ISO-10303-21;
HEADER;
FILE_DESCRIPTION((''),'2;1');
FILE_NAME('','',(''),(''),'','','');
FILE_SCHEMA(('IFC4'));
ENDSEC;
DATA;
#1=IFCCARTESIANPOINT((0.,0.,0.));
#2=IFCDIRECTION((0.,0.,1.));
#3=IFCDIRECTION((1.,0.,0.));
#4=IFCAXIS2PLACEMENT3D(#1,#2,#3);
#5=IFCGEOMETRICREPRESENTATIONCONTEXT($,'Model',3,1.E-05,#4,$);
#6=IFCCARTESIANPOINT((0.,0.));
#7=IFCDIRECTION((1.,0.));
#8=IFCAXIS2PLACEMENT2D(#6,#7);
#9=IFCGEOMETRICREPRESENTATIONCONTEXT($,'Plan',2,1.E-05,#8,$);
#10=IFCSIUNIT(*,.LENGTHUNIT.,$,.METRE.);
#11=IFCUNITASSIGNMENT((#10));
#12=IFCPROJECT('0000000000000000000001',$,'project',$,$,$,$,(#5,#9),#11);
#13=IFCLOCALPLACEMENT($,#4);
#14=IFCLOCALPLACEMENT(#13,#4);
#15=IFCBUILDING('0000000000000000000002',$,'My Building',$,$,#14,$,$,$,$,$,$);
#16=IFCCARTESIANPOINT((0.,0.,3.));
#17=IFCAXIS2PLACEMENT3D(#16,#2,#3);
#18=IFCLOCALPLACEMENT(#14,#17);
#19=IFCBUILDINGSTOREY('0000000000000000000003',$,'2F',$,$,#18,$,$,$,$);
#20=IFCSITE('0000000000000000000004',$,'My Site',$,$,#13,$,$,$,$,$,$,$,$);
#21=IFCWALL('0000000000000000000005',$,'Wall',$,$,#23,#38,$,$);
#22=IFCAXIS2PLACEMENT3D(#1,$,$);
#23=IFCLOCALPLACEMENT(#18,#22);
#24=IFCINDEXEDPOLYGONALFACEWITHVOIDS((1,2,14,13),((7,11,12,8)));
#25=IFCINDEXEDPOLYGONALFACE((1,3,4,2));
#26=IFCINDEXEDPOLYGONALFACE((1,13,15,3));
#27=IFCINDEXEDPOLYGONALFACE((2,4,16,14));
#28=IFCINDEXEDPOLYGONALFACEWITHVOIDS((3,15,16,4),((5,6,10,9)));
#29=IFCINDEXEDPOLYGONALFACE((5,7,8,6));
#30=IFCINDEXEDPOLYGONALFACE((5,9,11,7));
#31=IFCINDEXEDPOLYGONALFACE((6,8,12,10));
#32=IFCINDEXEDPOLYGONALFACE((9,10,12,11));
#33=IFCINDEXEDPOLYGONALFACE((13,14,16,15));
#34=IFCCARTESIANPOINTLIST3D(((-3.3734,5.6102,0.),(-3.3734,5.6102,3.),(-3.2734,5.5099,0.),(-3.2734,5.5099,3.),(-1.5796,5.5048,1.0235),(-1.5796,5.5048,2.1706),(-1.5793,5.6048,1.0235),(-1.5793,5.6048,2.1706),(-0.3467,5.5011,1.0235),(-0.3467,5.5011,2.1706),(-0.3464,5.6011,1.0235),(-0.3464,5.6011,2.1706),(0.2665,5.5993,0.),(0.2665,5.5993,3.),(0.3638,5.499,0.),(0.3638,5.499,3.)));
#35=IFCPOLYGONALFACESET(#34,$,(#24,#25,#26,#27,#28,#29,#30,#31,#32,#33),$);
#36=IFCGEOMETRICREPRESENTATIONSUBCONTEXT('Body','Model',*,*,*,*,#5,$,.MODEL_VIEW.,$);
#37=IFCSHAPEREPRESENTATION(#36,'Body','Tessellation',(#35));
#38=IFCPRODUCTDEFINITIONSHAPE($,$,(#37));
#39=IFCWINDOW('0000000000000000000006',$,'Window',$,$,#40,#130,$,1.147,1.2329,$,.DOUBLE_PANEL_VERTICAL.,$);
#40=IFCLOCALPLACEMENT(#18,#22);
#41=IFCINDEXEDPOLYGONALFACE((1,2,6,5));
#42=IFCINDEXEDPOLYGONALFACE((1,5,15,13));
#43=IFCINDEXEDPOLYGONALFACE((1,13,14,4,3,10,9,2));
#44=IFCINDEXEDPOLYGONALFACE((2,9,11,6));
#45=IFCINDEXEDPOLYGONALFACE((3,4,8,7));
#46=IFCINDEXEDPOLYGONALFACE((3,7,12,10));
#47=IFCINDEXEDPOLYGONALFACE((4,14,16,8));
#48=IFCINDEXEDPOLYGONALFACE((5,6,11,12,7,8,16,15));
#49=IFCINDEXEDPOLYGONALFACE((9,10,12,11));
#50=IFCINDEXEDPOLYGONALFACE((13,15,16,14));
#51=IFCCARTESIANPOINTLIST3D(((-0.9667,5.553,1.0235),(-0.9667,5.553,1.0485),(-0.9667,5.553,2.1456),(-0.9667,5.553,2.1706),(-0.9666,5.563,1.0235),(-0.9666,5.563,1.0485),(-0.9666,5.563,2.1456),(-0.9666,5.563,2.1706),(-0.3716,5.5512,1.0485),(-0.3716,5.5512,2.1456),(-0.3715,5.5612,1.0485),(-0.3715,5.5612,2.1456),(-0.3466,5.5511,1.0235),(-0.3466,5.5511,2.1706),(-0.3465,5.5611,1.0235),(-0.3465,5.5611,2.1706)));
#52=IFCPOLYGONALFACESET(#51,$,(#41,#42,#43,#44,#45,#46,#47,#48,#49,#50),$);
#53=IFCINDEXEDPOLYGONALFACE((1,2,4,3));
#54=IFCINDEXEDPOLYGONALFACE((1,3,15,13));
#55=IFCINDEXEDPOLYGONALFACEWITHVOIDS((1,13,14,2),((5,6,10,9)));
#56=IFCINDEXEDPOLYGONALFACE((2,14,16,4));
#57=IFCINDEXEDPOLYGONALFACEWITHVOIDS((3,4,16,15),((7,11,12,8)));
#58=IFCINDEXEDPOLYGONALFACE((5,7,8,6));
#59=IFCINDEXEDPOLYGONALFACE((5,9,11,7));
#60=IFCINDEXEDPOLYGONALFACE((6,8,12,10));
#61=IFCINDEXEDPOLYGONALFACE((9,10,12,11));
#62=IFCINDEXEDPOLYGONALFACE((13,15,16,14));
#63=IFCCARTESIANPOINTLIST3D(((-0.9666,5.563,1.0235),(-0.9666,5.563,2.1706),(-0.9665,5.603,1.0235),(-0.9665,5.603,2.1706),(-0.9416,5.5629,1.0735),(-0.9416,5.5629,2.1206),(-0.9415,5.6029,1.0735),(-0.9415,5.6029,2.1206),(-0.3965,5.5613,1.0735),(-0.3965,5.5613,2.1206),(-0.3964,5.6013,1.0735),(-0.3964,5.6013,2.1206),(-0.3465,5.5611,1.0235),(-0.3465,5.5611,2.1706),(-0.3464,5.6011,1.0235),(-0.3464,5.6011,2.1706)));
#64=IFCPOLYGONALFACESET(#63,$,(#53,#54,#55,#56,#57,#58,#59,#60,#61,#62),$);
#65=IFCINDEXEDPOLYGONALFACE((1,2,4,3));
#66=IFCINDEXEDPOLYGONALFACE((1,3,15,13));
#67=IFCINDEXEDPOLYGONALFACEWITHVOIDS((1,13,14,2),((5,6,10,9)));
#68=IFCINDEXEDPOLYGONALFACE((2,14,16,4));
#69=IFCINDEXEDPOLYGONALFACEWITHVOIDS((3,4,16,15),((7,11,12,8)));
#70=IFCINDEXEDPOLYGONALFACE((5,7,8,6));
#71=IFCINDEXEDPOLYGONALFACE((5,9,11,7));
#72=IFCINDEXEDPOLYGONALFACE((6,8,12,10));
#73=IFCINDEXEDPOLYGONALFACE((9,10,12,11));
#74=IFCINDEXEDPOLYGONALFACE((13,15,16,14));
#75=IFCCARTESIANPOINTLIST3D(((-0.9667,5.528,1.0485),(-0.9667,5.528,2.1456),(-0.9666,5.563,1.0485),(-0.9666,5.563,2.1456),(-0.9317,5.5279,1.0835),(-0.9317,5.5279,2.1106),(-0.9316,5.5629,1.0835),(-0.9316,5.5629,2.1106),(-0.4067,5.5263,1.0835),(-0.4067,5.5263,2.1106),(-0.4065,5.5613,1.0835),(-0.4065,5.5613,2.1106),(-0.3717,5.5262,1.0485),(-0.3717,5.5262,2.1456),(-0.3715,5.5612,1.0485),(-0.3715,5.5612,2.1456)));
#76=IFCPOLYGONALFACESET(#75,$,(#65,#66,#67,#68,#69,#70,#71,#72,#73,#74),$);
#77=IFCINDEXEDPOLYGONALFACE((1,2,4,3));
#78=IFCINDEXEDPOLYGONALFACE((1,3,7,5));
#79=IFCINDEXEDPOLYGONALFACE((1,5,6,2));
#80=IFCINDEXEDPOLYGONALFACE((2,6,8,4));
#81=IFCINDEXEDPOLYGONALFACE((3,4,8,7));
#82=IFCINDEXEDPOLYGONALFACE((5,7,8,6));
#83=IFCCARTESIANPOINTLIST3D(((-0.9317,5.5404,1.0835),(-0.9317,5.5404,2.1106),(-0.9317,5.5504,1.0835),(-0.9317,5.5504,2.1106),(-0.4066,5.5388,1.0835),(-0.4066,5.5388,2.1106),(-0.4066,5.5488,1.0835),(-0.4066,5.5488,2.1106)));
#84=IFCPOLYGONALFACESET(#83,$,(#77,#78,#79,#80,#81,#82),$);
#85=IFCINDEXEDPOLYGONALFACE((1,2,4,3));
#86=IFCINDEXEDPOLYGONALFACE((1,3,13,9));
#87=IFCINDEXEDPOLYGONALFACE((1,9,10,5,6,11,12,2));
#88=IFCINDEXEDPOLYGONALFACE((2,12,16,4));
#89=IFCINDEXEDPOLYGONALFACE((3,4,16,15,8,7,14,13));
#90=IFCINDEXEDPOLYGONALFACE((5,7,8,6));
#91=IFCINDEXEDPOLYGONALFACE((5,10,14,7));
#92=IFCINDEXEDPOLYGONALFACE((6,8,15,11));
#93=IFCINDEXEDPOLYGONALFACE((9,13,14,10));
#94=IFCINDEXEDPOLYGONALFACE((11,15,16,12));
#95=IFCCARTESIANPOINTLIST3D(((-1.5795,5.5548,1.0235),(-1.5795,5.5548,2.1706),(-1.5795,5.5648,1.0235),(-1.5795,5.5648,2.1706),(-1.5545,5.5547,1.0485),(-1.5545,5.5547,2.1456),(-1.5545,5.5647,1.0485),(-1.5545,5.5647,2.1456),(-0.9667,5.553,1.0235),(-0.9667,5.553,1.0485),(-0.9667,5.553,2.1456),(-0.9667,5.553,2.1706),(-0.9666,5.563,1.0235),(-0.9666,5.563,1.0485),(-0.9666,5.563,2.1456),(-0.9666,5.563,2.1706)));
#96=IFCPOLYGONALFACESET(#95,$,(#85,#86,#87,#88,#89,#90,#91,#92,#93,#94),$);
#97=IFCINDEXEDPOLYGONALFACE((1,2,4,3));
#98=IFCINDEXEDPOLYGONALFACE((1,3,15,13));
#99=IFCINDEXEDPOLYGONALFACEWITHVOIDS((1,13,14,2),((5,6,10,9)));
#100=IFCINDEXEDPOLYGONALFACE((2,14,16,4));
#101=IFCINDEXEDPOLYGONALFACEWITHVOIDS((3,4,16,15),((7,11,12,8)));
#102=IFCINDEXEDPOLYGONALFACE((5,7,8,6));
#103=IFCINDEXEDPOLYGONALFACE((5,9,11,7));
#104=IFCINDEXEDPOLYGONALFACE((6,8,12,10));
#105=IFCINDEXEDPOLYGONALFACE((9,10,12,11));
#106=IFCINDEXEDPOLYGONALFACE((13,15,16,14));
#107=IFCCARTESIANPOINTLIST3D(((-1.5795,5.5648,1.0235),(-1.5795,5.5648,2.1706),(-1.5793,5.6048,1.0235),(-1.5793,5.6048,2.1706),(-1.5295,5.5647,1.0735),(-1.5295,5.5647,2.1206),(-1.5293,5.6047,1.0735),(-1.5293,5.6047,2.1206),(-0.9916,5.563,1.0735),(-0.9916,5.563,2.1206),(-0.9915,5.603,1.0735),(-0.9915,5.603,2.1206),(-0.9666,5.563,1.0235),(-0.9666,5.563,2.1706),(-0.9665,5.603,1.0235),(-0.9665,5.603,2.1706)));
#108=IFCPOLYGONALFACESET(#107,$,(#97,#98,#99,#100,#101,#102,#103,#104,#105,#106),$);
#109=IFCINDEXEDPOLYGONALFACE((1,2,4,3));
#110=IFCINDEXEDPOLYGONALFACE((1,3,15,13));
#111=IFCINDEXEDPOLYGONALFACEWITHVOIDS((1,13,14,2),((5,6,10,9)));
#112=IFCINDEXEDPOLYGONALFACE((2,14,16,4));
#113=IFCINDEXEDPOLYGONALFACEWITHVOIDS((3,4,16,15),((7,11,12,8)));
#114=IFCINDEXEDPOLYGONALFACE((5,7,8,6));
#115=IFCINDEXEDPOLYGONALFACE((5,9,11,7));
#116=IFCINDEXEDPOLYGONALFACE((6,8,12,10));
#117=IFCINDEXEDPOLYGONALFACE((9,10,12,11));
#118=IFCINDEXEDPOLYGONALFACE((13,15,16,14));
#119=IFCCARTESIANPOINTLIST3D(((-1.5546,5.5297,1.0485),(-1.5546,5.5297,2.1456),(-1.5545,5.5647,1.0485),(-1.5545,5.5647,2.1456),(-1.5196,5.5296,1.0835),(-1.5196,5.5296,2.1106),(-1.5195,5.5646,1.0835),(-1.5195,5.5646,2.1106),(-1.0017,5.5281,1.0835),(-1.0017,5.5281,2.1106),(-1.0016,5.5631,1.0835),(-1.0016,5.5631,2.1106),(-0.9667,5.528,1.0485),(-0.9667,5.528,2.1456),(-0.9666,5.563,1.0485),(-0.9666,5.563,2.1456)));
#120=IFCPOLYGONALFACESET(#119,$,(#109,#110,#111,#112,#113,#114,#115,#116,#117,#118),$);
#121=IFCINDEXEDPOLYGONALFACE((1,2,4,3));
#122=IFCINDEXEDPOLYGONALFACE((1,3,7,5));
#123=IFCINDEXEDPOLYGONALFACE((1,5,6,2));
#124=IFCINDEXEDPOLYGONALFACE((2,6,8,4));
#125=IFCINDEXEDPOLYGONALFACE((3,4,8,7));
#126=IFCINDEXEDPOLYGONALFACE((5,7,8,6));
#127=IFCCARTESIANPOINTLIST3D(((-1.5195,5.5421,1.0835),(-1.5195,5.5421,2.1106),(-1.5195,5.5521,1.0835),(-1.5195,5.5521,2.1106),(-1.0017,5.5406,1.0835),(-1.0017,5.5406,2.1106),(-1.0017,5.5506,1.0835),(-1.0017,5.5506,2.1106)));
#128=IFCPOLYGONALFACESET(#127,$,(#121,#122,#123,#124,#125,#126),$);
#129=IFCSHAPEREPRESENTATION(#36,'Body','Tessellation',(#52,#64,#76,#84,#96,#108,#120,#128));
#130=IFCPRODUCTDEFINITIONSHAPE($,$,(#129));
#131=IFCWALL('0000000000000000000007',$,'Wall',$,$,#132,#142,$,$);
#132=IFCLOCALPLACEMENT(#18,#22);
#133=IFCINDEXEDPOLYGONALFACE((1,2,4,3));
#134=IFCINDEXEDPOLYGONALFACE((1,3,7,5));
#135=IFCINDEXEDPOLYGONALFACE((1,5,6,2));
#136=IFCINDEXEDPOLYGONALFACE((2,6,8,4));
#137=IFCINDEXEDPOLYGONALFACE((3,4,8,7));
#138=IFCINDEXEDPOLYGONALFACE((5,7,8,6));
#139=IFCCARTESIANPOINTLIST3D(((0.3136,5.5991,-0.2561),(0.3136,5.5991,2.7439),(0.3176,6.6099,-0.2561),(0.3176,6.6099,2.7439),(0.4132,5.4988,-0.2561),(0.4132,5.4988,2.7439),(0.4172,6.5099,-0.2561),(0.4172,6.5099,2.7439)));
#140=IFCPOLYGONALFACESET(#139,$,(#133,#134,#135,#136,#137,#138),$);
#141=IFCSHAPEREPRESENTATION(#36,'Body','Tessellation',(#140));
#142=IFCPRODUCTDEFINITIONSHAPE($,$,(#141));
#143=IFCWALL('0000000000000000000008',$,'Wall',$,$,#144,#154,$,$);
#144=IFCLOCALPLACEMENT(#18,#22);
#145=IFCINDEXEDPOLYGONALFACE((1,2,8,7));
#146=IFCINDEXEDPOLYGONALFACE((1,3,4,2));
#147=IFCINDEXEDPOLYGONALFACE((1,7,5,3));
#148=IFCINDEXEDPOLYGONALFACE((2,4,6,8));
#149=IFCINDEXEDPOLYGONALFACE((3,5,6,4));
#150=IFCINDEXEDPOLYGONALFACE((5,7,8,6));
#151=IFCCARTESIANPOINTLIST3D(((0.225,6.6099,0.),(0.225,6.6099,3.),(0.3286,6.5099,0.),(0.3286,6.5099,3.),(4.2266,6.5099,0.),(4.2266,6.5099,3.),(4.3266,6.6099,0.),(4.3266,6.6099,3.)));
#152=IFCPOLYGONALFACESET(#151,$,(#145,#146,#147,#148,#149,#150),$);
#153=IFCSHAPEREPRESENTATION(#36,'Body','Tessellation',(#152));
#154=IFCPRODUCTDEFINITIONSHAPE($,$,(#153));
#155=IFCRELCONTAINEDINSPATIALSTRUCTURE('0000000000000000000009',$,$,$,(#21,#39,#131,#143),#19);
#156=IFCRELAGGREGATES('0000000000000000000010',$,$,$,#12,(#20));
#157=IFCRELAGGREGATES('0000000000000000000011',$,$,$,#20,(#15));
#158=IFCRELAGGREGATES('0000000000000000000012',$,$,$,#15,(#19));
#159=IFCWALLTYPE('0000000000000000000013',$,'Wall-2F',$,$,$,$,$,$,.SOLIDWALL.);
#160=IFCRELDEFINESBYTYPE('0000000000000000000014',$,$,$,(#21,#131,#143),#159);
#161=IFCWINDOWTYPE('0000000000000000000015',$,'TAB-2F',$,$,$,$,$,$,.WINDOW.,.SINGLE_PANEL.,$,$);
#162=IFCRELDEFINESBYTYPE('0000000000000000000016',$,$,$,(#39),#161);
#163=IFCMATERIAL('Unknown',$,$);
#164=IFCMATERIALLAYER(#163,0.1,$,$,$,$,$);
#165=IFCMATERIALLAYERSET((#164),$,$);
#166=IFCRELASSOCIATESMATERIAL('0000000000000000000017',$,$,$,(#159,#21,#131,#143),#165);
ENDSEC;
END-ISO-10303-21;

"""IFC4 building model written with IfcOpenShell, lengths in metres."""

from ifc_helpers import new_model, entity, si_unit, frame, origin_with_axes, origin_2d_with_axis, place, context, subcontext, project, spatial, line, indexed_curve, outline, extrude, shape, source, transform, mapped, material, layer, layer_set, layer_usage, type_object, type_shapes, element, fill, save


model = new_model("IFC4")

# Units and contexts
model_context = context("Model", 3, precision=1e-05, world=origin_with_axes())
plan_context = context("Plan", 2, precision=1e-05, world=origin_2d_with_axis())
body_context_1 = subcontext(model_context, "Body", "Model", "MODEL_VIEW")
body_context_2 = subcontext(plan_context, "Body", "Plan", "PLAN_VIEW")
ifc_project = project(units=[si_unit("LENGTHUNIT", "METRE")], contexts=[model_context, plan_context])

# Site, building, storey
site_placement = place(None, origin_with_axes())
site = spatial("IfcSite", under=ifc_project, at=site_placement, Name="My Site")
building_placement = place(site_placement, origin_with_axes())
building = spatial("IfcBuilding", under=site, at=building_placement, Name="My Building")
storey_placement = place(building_placement, frame((0.0, 0.0, 3.0), z_axis=(0.0, 0.0, 1.0), x_axis=(1.0, 0.0, 0.0)))
storey = spatial("IfcBuildingStorey", under=building, at=storey_placement, Name="2F")

# Shared definitions
ifc_material = material(Name="Unknown")

# Shared definitions
ifc_layer_1 = layer(ifc_material, 0.1)
ifc_layer_set_1 = layer_set([ifc_layer_1])
wall_type = type_object("IfcWallType", Name="Wall-2F", PredefinedType="SOLIDWALL", material=ifc_layer_set_1)

# Wall, opening, window
ifc_layer_usage_1 = layer_usage(ifc_layer_set_1, "AXIS2", "NEGATIVE", 0.0)
wall_1_placement = place(storey_placement, frame((-3.2734, 5.6099, 0.0), z_axis=(0.0, 0.0, 1.0), x_axis=(0.999995, -0.003003, 0.0)))
wall_1 = element("IfcWall", 1, at=wall_1_placement, inside=storey, type_object=wall_type, material=ifc_layer_usage_1, Name="Wall", context=body_context_1, shape_type="SweptSolid", body=[
    extrude(outline(indexed_curve([(0.0003, -0.1), (-0.1, 0.0), (3.5399, 0.0), (3.6375, -0.1)], segments=[line(1, 2, 3, 4, 1)])), origin_with_axes(), (0.0, 0.0, 1.0), 3.0),
])
shared_shape_1 = source(origin_with_axes(), body_context_1, "Body", "SweptSolid", [
    extrude(outline(indexed_curve([(0.0, 0.0), (1.2329, 0.0), (1.2329, 1.147), (0.0, 1.147)], segments=[line(1, 2, 3, 4, 1)])), frame((0.0, -0.6, 0.0), z_axis=(0.0, -1.0, 0.0), x_axis=(1.0, 0.0, 0.0)), (0.0, 0.0, -1.0), 1.2),
])
opening_1_placement = place(wall_1_placement, frame((2.927, 0.05, 1.0235), z_axis=(0.0, 0.0, 1.0), x_axis=(-1.0, 0.0, 0.0)))
opening_1 = element("IfcOpeningElement", 2, at=opening_1_placement, cuts=wall_1, PredefinedType="OPENING", context=body_context_1, shape_type="MappedRepresentation", body=[
    mapped(shared_shape_1, transform((0.0, 0.0, 0.0), x_axis=(1.0, 0.0, 0.0), y_axis=(0.0, 1.0, 0.0), z_axis=(0.0, 0.0, 1.0), scale=1.0)),
])
window_type_1 = type_object("IfcWindowType", Name="TAB-2F", PartitioningType="SINGLE_PANEL", PredefinedType="WINDOW")
shared_shape_2 = source(origin_with_axes(), body_context_1, "Body", "SweptSolid", [
    extrude(outline(indexed_curve([(0.6201, 0.0), (0.0, 0.0), (0.0, 1.147), (0.6201, 1.147), (0.6201, 1.122), (0.025, 1.122), (0.025, 0.025), (0.6201, 0.025)], segments=[line(1, 2, 3, 4, 5, 6, 7, 8, 1)])), frame((0.0, 0.09, 0.0), z_axis=(0.0, -1.0, 0.0), x_axis=(1.0, 0.0, 0.0)), (0.0, 0.0, -1.0), 0.01),
    extrude(outline(indexed_curve([(0.0, 0.0), (0.6201, 0.0), (0.6201, 1.147), (0.0, 1.147)], segments=[line(1, 2, 3, 4, 1)]), holes=[indexed_curve([(0.05, 0.05), (0.5951, 0.05), (0.5951, 1.097), (0.05, 1.097)], segments=[line(1, 2, 3, 4, 1)])]), frame((0.0, 0.05, 0.0), z_axis=(0.0, -1.0, 0.0), x_axis=(1.0, 0.0, 0.0)), (0.0, 0.0, -1.0), 0.04),
    extrude(outline(indexed_curve([(0.0, 0.0), (0.5951, 0.0), (0.5951, 1.097), (0.0, 1.097)], segments=[line(1, 2, 3, 4, 1)]), holes=[indexed_curve([(0.035, 0.035), (0.5601, 0.035), (0.5601, 1.062), (0.035, 1.062)], segments=[line(1, 2, 3, 4, 1)])]), frame((0.025, 0.09, 0.025), z_axis=(0.0, -1.0, 0.0), x_axis=(1.0, 0.0, 0.0)), (0.0, 0.0, -1.0), 0.035),
    extrude(outline(indexed_curve([(0.035, 0.035), (0.5601, 0.035), (0.5601, 1.062), (0.035, 1.062)], segments=[line(1, 2, 3, 4, 1)])), frame((0.025, 0.1025, 0.025), z_axis=(0.0, -1.0, 0.0), x_axis=(1.0, 0.0, 0.0)), (0.0, 0.0, -1.0), 0.01),
    extrude(outline(indexed_curve([(0.0, 1.147), (0.6128, 1.147), (0.6128, 0.0), (0.0, 0.0), (0.0, 0.025), (0.5878, 0.025), (0.5878, 1.122), (0.0, 1.122)], segments=[line(1, 2, 3, 4, 5, 6, 7, 8, 1)])), frame((0.6201, 0.09, 0.0), z_axis=(0.0, -1.0, 0.0), x_axis=(1.0, 0.0, 0.0)), (0.0, 0.0, -1.0), 0.01),
    extrude(outline(indexed_curve([(0.0, 0.0), (0.6128, 0.0), (0.6128, 1.147), (0.0, 1.147)], segments=[line(1, 2, 3, 4, 1)]), holes=[indexed_curve([(0.025, 0.05), (0.5628, 0.05), (0.5628, 1.097), (0.025, 1.097)], segments=[line(1, 2, 3, 4, 1)])]), frame((0.6201, 0.05, 0.0), z_axis=(0.0, -1.0, 0.0), x_axis=(1.0, 0.0, 0.0)), (0.0, 0.0, -1.0), 0.04),
    extrude(outline(indexed_curve([(0.0, 0.0), (0.5878, 0.0), (0.5878, 1.097), (0.0, 1.097)], segments=[line(1, 2, 3, 4, 1)]), holes=[indexed_curve([(0.035, 0.035), (0.5528, 0.035), (0.5528, 1.062), (0.035, 1.062)], segments=[line(1, 2, 3, 4, 1)])]), frame((0.6201, 0.09, 0.025), z_axis=(0.0, -1.0, 0.0), x_axis=(1.0, 0.0, 0.0)), (0.0, 0.0, -1.0), 0.035),
    extrude(outline(indexed_curve([(0.035, 0.035), (0.5528, 0.035), (0.5528, 1.062), (0.035, 1.062)], segments=[line(1, 2, 3, 4, 1)])), frame((0.6201, 0.1025, 0.025), z_axis=(0.0, -1.0, 0.0), x_axis=(1.0, 0.0, 0.0)), (0.0, 0.0, -1.0), 0.01),
])
shared_shape_3 = source(origin_with_axes(), body_context_2, "Body", "Curve2D", [
    entity("IfcIndexedPolyCurve", entity("IfcCartesianPointList2D", [[0.05, 0.05], [0.5951, 0.05]])),
    entity("IfcIndexedPolyCurve", entity("IfcCartesianPointList2D", [[0.0, 0.1], [0.025, 0.1], [0.025, 0.09], [0.05, 0.09], [0.05, 0.05], [0.0, 0.05]]), [entity("IfcLineIndex", [1, 2, 3, 4, 5, 6, 1])]),
    entity("IfcIndexedPolyCurve", entity("IfcCartesianPointList2D", [[0.6201, 0.1], [0.6201, 0.1], [0.6201, 0.09], [0.5951, 0.09], [0.5951, 0.05], [0.6201, 0.05]])),
    entity("IfcIndexedPolyCurve", entity("IfcCartesianPointList2D", [[0.025, 0.09], [0.06, 0.09], [0.06, 0.125], [0.025, 0.125]]), [entity("IfcLineIndex", [1, 2, 3, 4, 1])]),
    entity("IfcIndexedPolyCurve", entity("IfcCartesianPointList2D", [[0.6201, 0.09], [0.5851, 0.09], [0.5851, 0.125], [0.6201, 0.125]]), [entity("IfcLineIndex", [1, 2, 3, 4, 1])]),
    entity("IfcIndexedPolyCurve", entity("IfcCartesianPointList2D", [[0.06, 0.09], [0.5851, 0.09]])),
    entity("IfcIndexedPolyCurve", entity("IfcCartesianPointList2D", [[0.06, 0.125], [0.5851, 0.125]])),
    entity("IfcIndexedPolyCurve", entity("IfcCartesianPointList2D", [[0.06, 0.1075], [0.5851, 0.1075]])),
    entity("IfcIndexedPolyCurve", entity("IfcCartesianPointList2D", [[0.6451, 0.05], [1.1829, 0.05]])),
    entity("IfcIndexedPolyCurve", entity("IfcCartesianPointList2D", [[0.6201, 0.1], [0.6201, 0.1], [0.6201, 0.09], [0.6451, 0.09], [0.6451, 0.05], [0.6201, 0.05]])),
    entity("IfcIndexedPolyCurve", entity("IfcCartesianPointList2D", [[1.2329, 0.1], [1.2079, 0.1], [1.2079, 0.09], [1.1829, 0.09], [1.1829, 0.05], [1.2329, 0.05]]), [entity("IfcLineIndex", [1, 2, 3, 4, 5, 6, 1])]),
    entity("IfcIndexedPolyCurve", entity("IfcCartesianPointList2D", [[0.6201, 0.09], [0.6551, 0.09], [0.6551, 0.125], [0.6201, 0.125]]), [entity("IfcLineIndex", [1, 2, 3, 4, 1])]),
    entity("IfcIndexedPolyCurve", entity("IfcCartesianPointList2D", [[1.2079, 0.09], [1.1729, 0.09], [1.1729, 0.125], [1.2079, 0.125]]), [entity("IfcLineIndex", [1, 2, 3, 4, 1])]),
    entity("IfcIndexedPolyCurve", entity("IfcCartesianPointList2D", [[0.6551, 0.09], [1.1729, 0.09]])),
    entity("IfcIndexedPolyCurve", entity("IfcCartesianPointList2D", [[0.6551, 0.125], [1.1729, 0.125]])),
    entity("IfcIndexedPolyCurve", entity("IfcCartesianPointList2D", [[0.6551, 0.1075], [1.1729, 0.1075]])),
])
type_shapes(window_type_1, [shared_shape_2, shared_shape_3])
window_1_placement = place(opening_1_placement, frame((0.0, 0.0, 0.0), z_axis=(0.0, 0.0, 1.0), x_axis=(1.0, 0.0, 0.0)))
window_1 = element("IfcWindow", 3, at=window_1_placement, inside=storey, type_object=window_type_1, Name="Window", OverallHeight=1.147, OverallWidth=1.2329, PartitioningType="DOUBLE_PANEL_VERTICAL", shapes=[
    shape(body_context_1, "Body", "MappedRepresentation", [mapped(shared_shape_2, transform((0.0, 0.0, 0.0), x_axis=(1.0, 0.0, 0.0), y_axis=(0.0, 1.0, 0.0), z_axis=(0.0, 0.0, 1.0), scale=1.0))]),
    shape(body_context_2, "Body", "MappedRepresentation", [mapped(shared_shape_3, transform((0.0, 0.0, 0.0), x_axis=(1.0, 0.0, 0.0), y_axis=(0.0, 1.0, 0.0), z_axis=(0.0, 0.0, 1.0), scale=1.0))]),
])
fill(opening_1, window_1)

# Walls
ifc_layer_usage_2 = layer_usage(ifc_layer_set_1, "AXIS2", "POSITIVE", 0.0)
wall_2_placement = place(storey_placement, frame((0.4132, 5.4988, -0.2561), z_axis=(0.0, 0.0, 1.0), x_axis=(0.00404, 0.999992, 0.0)))
element("IfcWall", 4, at=wall_2_placement, inside=storey, type_object=wall_type, material=ifc_layer_usage_2, Name="Wall", context=body_context_1, shape_type="SweptSolid", body=[
    extrude(outline(indexed_curve([(0.0, 0.0), (0.0999, 0.1), (1.1107, 0.1), (1.0111, 0.0)], segments=[line(1, 2, 3, 4, 1)])), origin_with_axes(), (0.0, 0.0, 1.0), 3.0),
])
ifc_layer_usage_3 = layer_usage(ifc_layer_set_1, "AXIS2", "POSITIVE", 0.0)
wall_3_placement = place(storey_placement, frame((0.3286, 6.5099, 0.0), z_axis=(0.0, 0.0, 1.0), x_axis=(1.0, 0.0, 0.0)))
element("IfcWall", 5, at=wall_3_placement, inside=storey, type_object=wall_type, material=ifc_layer_usage_3, Name="Wall", context=body_context_1, shape_type="SweptSolid", body=[
    extrude(outline(indexed_curve([(0.0, 0.0), (-0.1037, 0.1), (3.998, 0.1), (3.898, 0.0)], segments=[line(1, 2, 3, 4, 1)])), origin_with_axes(), (0.0, 0.0, 1.0), 3.0),
])

save(model, "model.ifc")
